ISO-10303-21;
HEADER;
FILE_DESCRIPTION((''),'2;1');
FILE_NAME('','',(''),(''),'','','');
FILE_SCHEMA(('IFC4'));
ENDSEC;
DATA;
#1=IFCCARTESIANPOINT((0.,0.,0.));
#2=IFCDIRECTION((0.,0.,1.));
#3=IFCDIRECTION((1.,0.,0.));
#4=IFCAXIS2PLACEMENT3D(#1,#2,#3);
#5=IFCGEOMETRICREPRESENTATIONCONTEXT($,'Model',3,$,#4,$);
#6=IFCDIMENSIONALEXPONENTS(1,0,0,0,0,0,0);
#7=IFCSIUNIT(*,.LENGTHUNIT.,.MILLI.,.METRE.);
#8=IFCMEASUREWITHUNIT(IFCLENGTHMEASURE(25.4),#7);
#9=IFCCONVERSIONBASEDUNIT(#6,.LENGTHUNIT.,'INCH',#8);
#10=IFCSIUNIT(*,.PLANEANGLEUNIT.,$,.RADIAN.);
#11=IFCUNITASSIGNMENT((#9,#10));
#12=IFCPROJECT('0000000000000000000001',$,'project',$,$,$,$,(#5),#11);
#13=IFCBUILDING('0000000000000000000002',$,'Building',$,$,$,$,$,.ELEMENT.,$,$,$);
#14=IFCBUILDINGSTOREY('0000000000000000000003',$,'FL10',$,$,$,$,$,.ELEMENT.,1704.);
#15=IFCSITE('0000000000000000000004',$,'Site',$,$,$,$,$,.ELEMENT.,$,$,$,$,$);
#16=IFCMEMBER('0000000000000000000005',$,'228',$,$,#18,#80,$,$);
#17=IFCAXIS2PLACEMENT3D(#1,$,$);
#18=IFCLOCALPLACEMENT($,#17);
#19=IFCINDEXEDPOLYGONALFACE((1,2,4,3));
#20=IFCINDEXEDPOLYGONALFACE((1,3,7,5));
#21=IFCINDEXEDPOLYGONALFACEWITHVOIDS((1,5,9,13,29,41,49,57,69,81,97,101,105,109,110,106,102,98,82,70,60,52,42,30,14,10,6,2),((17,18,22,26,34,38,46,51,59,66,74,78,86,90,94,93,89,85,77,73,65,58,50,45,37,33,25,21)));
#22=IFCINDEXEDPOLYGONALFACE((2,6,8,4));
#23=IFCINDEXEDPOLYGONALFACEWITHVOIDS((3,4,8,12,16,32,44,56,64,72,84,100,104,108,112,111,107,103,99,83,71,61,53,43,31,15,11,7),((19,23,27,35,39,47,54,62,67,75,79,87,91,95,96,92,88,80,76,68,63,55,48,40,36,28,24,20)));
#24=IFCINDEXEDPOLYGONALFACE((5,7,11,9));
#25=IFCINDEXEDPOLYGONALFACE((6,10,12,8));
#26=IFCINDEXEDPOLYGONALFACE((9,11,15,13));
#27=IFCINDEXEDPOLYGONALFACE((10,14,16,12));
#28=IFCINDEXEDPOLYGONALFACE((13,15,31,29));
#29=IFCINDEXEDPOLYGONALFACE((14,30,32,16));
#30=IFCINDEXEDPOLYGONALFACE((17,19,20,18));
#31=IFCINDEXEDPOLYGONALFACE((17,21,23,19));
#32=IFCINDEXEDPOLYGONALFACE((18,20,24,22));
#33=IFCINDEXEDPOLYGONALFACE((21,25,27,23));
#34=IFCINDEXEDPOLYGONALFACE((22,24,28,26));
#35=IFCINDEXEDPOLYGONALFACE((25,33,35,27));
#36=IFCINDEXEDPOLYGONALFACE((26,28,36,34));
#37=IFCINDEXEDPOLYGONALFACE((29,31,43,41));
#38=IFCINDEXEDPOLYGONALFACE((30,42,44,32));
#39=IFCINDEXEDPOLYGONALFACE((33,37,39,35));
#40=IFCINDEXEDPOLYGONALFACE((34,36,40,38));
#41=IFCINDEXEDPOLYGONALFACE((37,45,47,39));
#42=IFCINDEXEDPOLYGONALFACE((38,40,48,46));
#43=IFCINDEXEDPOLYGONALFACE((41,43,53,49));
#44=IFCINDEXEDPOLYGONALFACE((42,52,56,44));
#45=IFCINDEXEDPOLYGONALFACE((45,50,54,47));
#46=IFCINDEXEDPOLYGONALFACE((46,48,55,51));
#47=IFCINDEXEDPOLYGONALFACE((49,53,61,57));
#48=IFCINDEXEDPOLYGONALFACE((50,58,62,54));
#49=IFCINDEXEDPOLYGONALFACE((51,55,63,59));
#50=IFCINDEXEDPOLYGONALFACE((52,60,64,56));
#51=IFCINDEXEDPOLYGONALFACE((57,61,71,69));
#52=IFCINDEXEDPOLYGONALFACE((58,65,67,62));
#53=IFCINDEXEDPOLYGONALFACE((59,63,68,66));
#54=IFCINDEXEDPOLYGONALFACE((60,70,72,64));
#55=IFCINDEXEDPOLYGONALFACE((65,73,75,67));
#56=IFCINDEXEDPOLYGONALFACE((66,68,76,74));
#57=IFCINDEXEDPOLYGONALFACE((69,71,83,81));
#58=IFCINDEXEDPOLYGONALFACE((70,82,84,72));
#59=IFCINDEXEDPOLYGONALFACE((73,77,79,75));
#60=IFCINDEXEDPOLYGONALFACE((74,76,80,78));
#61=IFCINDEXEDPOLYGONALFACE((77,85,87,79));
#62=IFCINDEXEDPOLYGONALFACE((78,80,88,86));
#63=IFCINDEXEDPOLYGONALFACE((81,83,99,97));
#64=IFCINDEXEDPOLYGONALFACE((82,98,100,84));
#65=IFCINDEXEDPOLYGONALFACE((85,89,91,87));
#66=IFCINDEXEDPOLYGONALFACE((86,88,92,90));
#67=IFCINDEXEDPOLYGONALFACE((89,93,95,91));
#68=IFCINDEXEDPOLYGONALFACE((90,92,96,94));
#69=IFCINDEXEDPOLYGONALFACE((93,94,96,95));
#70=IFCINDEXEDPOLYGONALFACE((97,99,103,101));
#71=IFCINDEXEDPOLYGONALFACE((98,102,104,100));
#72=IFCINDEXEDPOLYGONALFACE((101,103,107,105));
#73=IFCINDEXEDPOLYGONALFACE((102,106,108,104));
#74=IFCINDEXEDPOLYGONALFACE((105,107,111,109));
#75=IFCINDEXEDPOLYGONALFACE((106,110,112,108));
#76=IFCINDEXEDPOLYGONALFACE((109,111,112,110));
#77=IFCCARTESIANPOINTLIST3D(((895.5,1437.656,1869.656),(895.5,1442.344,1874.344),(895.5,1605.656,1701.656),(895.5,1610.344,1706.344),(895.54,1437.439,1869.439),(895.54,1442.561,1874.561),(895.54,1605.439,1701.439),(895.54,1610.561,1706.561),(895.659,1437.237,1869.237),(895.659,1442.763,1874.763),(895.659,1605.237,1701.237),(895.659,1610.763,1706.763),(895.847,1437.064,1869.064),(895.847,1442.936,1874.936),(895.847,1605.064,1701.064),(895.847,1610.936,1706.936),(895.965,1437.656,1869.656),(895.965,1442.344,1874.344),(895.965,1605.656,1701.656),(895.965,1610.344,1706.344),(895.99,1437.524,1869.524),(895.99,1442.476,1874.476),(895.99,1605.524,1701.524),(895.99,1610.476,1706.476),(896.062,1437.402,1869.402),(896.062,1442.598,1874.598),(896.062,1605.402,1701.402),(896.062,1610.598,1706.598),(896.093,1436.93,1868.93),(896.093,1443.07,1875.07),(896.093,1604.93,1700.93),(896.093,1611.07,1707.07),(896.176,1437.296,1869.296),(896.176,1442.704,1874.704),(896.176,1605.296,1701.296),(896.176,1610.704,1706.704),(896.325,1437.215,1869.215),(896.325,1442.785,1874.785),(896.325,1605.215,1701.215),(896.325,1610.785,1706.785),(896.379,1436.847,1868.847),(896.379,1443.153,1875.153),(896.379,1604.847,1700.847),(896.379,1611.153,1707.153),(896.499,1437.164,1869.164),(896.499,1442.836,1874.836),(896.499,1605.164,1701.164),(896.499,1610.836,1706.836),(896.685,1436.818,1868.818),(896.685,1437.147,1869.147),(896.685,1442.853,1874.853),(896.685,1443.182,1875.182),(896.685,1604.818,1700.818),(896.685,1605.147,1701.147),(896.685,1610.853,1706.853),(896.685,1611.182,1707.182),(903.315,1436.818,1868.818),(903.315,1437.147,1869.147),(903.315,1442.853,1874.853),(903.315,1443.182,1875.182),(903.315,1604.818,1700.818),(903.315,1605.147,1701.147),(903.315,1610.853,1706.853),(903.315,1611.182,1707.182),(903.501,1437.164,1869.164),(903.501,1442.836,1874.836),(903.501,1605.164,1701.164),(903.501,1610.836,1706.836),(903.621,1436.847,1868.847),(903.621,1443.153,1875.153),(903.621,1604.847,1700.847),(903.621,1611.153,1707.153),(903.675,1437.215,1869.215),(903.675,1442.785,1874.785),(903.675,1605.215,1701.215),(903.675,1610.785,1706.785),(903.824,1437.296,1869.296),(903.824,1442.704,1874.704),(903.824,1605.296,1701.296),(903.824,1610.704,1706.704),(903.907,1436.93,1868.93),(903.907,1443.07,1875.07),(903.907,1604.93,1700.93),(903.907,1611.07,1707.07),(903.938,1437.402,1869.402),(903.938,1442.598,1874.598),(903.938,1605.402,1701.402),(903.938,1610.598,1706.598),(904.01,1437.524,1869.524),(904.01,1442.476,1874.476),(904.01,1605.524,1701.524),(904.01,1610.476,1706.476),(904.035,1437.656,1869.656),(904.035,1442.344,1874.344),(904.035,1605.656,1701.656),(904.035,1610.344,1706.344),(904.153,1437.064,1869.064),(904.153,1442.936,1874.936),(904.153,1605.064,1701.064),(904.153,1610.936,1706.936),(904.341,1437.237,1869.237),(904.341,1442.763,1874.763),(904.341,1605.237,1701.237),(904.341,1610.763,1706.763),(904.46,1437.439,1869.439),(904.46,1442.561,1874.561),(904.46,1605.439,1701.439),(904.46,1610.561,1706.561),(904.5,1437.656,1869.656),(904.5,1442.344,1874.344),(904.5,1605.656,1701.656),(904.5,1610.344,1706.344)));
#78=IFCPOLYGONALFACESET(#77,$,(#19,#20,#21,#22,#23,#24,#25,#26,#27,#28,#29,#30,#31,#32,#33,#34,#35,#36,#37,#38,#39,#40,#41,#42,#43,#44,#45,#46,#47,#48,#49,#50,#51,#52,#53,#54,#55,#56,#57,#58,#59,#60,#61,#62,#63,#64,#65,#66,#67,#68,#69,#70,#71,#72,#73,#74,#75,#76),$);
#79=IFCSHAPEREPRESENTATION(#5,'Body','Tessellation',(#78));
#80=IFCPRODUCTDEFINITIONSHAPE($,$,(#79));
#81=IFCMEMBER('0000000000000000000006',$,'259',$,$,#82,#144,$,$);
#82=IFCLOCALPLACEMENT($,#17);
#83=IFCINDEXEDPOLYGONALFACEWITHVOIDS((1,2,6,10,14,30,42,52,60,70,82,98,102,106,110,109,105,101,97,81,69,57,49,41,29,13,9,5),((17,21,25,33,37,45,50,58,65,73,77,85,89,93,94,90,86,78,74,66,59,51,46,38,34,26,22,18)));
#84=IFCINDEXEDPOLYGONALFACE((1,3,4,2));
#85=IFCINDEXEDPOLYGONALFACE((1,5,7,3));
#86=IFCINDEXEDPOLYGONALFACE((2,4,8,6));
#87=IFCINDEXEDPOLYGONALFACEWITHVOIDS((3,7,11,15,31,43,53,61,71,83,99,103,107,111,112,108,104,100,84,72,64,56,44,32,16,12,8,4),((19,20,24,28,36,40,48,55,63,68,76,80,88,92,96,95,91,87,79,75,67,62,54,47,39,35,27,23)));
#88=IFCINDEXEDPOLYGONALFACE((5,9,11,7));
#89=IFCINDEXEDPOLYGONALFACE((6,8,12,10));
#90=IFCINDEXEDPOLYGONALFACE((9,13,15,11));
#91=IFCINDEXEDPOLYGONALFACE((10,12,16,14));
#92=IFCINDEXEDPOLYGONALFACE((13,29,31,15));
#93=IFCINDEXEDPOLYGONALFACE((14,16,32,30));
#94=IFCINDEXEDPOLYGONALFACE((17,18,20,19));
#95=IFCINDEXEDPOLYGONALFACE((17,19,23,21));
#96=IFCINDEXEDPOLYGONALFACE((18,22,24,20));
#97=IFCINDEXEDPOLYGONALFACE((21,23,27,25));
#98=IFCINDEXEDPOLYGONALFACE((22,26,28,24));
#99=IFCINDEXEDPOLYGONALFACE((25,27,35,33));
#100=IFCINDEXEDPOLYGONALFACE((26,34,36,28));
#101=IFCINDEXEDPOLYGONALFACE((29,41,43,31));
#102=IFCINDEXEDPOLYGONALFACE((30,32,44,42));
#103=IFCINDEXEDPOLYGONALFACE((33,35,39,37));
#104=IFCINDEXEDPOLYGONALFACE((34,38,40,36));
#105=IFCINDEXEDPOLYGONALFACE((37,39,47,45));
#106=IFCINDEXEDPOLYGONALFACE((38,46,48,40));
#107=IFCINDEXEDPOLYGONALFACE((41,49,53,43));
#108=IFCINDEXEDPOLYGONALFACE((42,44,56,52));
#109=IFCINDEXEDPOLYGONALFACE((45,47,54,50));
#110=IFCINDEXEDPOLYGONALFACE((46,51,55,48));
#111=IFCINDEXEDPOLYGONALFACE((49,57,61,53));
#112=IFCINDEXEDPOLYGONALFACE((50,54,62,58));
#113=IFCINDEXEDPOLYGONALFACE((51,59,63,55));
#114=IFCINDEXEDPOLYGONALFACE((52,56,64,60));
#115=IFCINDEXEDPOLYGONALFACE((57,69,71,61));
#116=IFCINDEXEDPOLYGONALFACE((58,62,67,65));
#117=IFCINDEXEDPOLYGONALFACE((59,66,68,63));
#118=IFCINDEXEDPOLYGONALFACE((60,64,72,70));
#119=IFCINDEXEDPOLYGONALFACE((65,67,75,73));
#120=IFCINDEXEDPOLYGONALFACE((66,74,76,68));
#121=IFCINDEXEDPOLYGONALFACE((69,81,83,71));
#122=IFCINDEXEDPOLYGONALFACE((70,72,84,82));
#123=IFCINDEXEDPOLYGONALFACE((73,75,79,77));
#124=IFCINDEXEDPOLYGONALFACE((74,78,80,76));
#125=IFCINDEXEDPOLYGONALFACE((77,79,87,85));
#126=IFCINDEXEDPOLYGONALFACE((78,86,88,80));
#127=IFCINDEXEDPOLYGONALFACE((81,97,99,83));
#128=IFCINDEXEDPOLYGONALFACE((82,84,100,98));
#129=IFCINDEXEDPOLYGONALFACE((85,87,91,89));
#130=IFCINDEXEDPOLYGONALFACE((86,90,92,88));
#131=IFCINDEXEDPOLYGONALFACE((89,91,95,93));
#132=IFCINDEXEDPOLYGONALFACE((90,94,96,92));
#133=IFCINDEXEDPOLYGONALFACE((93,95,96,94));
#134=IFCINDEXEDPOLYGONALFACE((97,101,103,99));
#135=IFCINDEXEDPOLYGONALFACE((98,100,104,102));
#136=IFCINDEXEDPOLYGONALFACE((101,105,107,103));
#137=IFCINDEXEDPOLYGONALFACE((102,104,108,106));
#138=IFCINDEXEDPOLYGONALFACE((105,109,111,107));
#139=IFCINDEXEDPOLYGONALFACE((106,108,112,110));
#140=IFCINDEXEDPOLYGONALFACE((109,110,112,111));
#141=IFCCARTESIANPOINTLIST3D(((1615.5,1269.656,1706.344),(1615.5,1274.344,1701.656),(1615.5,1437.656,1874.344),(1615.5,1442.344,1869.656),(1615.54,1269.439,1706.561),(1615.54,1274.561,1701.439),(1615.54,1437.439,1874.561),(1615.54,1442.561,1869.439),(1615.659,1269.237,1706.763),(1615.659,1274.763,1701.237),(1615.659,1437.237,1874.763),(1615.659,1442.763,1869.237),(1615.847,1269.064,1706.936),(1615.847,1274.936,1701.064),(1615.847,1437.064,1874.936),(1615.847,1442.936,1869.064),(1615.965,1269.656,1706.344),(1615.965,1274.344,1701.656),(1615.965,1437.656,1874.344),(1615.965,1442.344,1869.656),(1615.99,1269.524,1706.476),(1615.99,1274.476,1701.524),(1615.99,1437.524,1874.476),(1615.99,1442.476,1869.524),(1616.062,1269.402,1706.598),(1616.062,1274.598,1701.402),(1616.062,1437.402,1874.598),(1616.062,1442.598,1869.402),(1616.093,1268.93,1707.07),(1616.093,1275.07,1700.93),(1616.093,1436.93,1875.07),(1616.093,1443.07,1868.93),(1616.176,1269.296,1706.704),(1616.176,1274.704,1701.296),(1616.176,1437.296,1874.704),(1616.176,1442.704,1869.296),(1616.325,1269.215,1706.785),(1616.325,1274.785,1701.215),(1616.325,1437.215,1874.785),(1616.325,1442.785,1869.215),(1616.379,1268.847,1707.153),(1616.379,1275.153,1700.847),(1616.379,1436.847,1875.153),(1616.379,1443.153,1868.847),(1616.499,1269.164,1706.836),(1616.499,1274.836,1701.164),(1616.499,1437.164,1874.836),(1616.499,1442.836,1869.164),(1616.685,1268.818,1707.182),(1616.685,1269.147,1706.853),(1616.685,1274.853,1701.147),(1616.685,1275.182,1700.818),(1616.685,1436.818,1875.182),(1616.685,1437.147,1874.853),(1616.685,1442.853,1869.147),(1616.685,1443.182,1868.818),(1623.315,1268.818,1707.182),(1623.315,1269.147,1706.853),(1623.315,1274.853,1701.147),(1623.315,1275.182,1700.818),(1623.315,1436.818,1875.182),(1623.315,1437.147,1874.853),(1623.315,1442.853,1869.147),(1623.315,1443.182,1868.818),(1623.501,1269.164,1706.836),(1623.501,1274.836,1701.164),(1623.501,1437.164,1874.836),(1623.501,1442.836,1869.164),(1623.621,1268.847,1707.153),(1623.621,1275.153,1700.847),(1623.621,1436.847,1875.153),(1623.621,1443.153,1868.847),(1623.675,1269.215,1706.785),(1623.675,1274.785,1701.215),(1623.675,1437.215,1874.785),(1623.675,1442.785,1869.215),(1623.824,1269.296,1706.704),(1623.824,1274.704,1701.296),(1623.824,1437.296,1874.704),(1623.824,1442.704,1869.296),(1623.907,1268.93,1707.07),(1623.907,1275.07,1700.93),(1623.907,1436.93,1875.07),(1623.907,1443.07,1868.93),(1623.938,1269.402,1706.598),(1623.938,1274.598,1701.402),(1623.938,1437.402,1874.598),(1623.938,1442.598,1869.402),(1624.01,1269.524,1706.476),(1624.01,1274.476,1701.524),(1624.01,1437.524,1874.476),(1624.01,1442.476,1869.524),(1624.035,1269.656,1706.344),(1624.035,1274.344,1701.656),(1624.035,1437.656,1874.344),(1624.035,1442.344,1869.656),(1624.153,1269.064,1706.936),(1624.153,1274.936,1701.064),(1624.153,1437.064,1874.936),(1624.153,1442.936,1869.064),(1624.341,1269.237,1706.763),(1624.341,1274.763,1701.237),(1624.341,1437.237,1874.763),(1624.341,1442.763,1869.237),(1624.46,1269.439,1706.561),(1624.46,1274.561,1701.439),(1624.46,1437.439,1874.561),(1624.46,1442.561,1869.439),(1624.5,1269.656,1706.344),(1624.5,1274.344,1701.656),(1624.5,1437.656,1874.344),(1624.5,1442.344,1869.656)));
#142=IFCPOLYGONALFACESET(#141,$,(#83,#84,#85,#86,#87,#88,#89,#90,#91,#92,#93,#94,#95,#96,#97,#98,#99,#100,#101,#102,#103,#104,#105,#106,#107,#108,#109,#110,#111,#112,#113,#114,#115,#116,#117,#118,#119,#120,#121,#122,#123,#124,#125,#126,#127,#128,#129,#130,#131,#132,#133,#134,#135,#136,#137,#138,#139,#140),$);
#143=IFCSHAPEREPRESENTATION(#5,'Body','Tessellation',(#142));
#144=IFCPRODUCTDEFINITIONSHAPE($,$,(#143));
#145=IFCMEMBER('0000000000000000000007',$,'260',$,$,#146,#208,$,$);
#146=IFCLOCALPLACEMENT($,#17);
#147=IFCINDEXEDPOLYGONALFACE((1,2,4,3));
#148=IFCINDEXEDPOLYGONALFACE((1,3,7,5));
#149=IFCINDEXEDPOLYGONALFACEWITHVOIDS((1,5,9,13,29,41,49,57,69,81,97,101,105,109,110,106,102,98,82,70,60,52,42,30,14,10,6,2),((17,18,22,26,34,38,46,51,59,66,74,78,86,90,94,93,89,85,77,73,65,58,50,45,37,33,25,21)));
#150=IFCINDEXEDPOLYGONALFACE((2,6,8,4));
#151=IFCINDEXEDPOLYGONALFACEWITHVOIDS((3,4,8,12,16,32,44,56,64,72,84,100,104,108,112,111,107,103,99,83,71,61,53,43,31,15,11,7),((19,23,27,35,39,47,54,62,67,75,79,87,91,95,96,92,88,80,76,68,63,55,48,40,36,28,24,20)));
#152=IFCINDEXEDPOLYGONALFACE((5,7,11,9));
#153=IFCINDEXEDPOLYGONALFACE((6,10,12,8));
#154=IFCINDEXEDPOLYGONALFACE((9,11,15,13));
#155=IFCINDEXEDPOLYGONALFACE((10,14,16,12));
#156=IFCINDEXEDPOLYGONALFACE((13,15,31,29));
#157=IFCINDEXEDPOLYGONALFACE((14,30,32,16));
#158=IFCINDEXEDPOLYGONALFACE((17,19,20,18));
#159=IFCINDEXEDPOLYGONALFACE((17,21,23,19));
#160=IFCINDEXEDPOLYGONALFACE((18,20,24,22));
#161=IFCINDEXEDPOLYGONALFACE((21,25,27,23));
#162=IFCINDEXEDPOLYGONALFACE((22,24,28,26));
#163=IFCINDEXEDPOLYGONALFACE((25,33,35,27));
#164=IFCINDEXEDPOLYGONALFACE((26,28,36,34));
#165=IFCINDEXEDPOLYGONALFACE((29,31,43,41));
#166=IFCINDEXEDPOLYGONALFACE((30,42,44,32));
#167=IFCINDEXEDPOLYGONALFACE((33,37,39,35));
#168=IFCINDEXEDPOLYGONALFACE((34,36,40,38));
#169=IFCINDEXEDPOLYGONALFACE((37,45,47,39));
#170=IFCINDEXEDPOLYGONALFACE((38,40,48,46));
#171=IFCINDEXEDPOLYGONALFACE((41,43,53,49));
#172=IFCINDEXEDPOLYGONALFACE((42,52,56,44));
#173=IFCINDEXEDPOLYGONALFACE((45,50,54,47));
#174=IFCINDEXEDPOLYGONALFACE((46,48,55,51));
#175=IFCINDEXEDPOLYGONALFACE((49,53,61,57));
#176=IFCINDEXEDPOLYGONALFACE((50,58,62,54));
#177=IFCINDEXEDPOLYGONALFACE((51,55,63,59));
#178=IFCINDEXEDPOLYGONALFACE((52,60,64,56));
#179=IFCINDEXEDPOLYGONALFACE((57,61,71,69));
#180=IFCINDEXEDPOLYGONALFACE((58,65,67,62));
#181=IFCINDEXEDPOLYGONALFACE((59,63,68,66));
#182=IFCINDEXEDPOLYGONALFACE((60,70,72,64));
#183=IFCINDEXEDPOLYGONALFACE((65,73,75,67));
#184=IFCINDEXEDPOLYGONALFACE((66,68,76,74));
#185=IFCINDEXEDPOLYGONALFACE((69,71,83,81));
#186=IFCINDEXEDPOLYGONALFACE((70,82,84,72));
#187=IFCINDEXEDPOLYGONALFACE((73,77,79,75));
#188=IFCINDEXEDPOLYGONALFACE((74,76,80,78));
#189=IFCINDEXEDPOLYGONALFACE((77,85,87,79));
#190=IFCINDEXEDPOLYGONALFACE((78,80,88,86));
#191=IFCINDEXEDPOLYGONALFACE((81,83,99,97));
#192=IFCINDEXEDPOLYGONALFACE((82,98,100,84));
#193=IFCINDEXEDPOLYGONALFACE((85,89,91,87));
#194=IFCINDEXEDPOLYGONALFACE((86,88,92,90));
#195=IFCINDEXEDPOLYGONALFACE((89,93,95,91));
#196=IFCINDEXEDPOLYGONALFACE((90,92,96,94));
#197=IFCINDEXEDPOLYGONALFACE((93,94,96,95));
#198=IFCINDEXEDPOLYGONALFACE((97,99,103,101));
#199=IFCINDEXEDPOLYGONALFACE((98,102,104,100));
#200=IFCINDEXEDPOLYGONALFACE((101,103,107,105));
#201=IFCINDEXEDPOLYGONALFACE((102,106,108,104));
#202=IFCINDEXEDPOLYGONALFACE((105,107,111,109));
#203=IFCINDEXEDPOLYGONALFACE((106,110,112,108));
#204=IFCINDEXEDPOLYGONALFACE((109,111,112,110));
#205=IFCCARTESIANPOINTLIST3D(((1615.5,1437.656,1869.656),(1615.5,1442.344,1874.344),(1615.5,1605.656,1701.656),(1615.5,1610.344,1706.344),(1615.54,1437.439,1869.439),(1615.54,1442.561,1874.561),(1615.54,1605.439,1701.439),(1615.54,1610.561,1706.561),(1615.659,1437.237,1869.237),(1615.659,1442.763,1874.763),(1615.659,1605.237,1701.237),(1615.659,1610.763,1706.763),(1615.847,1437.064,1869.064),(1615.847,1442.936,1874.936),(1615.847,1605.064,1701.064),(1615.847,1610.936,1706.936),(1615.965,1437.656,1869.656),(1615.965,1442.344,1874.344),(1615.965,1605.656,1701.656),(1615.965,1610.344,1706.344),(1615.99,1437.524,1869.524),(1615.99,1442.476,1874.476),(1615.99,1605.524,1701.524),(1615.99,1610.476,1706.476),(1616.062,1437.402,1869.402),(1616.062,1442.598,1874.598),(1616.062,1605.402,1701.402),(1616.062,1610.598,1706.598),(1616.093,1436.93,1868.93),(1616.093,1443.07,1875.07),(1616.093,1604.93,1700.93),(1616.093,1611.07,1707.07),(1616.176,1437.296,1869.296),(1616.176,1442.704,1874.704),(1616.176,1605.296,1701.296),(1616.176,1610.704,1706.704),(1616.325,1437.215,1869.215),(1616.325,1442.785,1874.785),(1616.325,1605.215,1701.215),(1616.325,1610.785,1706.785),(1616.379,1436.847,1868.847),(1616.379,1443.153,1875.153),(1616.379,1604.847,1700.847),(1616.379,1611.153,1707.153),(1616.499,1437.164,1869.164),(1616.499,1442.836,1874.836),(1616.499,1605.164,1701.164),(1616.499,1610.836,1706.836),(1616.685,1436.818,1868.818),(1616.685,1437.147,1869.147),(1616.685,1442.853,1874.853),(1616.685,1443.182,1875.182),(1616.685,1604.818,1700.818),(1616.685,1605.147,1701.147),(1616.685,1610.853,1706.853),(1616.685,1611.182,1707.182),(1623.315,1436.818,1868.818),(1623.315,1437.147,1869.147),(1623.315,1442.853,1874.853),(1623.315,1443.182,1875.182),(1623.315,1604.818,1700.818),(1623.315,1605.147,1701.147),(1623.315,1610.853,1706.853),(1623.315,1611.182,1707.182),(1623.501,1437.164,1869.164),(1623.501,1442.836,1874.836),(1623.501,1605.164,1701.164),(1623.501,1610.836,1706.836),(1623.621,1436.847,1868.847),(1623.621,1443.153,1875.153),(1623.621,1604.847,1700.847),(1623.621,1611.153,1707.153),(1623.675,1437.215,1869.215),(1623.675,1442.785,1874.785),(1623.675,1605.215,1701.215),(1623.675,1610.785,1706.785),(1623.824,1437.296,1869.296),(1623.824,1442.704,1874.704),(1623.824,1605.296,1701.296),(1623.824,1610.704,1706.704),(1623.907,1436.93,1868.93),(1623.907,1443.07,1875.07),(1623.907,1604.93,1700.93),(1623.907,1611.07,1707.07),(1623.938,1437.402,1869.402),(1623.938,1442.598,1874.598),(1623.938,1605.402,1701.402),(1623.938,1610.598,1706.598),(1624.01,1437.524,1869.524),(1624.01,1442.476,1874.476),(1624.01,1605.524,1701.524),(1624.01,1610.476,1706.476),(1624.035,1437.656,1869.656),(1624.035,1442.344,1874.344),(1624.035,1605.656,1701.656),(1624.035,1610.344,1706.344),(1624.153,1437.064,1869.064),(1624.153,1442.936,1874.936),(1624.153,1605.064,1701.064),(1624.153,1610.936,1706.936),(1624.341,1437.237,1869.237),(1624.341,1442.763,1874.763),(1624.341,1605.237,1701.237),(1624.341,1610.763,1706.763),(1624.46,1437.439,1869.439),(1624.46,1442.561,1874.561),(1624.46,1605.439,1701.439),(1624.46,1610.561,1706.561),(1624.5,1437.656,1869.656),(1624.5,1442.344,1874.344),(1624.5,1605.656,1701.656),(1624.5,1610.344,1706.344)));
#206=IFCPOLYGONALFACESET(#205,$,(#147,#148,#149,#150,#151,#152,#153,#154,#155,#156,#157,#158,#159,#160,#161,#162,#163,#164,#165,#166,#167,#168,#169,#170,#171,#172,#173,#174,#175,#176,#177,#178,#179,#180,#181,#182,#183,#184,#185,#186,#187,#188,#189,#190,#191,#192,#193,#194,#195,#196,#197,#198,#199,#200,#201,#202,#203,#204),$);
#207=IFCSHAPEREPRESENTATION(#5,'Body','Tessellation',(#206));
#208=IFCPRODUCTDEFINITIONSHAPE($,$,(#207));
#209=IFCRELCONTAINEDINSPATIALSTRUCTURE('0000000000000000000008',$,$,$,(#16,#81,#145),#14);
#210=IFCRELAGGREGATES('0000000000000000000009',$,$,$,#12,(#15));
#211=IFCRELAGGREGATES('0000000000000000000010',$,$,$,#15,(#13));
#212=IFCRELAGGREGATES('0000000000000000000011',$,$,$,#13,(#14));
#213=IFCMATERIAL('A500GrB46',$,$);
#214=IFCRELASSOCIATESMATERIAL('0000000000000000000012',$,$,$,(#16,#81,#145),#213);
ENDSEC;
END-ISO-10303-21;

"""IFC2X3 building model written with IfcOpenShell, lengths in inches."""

from ifc_helpers import new_model, entity, si_unit, converted_unit, frame, origin_with_axes, origin_2d_with_axis, place, context, project, spatial, hollow_rectangle, extrude, material, element, save


model = new_model("IFC2X3")

# Units and contexts
model_context = context("Model", 3, world=origin_with_axes())
ifc_project = project(units=[converted_unit("LENGTHUNIT", "INCH", entity("IfcLengthMeasure", 25.4), si_unit("LENGTHUNIT", "METRE", prefix="MILLI"), dimensions=[1, 0, 0, 0, 0, 0, 0]), si_unit("PLANEANGLEUNIT", "RADIAN")], contexts=[model_context])

# Site, building, storey
site = spatial("IfcSite", under=ifc_project, Name="Site", CompositionType="ELEMENT")
building = spatial("IfcBuilding", under=site, Name="Building", CompositionType="ELEMENT")
storey = spatial("IfcBuildingStorey", under=building, Name="FL10", CompositionType="ELEMENT", Elevation=1704.0)

# Members
ifc_material_1 = material(Name="A500GrB46")
for number, where, z_axis, x_axis, name in (
    (1, (900.0, 1608.0, 1704.0), (0.0, -0.707107, 0.707107), (1.0, 0.0, 0.0), "228"),
    (2, (1620.0, 1272.0, 1704.0), (0.0, 0.707107, 0.707107), (-1.0, 0.0, 0.0), "259"),
    (3, (1620.0, 1608.0, 1704.0), (0.0, -0.707107, 0.707107), (1.0, 0.0, 0.0), "260"),
):
    element("IfcMember", number, at=place(None, frame(where, z_axis=z_axis, x_axis=x_axis)), inside=storey, material=ifc_material_1, Name=name, context=model_context, shape_type="SweptSolid", body=[
        extrude(hollow_rectangle(XDim=9.0, YDim=9.0, WallThickness=0.465, InnerFilletRadius=0.72, OuterFilletRadius=1.185, at=origin_2d_with_axis()), origin_with_axes(), (0.0, 0.0, 1.0), 237.588),
    ])

save(model, "model.ifc")
